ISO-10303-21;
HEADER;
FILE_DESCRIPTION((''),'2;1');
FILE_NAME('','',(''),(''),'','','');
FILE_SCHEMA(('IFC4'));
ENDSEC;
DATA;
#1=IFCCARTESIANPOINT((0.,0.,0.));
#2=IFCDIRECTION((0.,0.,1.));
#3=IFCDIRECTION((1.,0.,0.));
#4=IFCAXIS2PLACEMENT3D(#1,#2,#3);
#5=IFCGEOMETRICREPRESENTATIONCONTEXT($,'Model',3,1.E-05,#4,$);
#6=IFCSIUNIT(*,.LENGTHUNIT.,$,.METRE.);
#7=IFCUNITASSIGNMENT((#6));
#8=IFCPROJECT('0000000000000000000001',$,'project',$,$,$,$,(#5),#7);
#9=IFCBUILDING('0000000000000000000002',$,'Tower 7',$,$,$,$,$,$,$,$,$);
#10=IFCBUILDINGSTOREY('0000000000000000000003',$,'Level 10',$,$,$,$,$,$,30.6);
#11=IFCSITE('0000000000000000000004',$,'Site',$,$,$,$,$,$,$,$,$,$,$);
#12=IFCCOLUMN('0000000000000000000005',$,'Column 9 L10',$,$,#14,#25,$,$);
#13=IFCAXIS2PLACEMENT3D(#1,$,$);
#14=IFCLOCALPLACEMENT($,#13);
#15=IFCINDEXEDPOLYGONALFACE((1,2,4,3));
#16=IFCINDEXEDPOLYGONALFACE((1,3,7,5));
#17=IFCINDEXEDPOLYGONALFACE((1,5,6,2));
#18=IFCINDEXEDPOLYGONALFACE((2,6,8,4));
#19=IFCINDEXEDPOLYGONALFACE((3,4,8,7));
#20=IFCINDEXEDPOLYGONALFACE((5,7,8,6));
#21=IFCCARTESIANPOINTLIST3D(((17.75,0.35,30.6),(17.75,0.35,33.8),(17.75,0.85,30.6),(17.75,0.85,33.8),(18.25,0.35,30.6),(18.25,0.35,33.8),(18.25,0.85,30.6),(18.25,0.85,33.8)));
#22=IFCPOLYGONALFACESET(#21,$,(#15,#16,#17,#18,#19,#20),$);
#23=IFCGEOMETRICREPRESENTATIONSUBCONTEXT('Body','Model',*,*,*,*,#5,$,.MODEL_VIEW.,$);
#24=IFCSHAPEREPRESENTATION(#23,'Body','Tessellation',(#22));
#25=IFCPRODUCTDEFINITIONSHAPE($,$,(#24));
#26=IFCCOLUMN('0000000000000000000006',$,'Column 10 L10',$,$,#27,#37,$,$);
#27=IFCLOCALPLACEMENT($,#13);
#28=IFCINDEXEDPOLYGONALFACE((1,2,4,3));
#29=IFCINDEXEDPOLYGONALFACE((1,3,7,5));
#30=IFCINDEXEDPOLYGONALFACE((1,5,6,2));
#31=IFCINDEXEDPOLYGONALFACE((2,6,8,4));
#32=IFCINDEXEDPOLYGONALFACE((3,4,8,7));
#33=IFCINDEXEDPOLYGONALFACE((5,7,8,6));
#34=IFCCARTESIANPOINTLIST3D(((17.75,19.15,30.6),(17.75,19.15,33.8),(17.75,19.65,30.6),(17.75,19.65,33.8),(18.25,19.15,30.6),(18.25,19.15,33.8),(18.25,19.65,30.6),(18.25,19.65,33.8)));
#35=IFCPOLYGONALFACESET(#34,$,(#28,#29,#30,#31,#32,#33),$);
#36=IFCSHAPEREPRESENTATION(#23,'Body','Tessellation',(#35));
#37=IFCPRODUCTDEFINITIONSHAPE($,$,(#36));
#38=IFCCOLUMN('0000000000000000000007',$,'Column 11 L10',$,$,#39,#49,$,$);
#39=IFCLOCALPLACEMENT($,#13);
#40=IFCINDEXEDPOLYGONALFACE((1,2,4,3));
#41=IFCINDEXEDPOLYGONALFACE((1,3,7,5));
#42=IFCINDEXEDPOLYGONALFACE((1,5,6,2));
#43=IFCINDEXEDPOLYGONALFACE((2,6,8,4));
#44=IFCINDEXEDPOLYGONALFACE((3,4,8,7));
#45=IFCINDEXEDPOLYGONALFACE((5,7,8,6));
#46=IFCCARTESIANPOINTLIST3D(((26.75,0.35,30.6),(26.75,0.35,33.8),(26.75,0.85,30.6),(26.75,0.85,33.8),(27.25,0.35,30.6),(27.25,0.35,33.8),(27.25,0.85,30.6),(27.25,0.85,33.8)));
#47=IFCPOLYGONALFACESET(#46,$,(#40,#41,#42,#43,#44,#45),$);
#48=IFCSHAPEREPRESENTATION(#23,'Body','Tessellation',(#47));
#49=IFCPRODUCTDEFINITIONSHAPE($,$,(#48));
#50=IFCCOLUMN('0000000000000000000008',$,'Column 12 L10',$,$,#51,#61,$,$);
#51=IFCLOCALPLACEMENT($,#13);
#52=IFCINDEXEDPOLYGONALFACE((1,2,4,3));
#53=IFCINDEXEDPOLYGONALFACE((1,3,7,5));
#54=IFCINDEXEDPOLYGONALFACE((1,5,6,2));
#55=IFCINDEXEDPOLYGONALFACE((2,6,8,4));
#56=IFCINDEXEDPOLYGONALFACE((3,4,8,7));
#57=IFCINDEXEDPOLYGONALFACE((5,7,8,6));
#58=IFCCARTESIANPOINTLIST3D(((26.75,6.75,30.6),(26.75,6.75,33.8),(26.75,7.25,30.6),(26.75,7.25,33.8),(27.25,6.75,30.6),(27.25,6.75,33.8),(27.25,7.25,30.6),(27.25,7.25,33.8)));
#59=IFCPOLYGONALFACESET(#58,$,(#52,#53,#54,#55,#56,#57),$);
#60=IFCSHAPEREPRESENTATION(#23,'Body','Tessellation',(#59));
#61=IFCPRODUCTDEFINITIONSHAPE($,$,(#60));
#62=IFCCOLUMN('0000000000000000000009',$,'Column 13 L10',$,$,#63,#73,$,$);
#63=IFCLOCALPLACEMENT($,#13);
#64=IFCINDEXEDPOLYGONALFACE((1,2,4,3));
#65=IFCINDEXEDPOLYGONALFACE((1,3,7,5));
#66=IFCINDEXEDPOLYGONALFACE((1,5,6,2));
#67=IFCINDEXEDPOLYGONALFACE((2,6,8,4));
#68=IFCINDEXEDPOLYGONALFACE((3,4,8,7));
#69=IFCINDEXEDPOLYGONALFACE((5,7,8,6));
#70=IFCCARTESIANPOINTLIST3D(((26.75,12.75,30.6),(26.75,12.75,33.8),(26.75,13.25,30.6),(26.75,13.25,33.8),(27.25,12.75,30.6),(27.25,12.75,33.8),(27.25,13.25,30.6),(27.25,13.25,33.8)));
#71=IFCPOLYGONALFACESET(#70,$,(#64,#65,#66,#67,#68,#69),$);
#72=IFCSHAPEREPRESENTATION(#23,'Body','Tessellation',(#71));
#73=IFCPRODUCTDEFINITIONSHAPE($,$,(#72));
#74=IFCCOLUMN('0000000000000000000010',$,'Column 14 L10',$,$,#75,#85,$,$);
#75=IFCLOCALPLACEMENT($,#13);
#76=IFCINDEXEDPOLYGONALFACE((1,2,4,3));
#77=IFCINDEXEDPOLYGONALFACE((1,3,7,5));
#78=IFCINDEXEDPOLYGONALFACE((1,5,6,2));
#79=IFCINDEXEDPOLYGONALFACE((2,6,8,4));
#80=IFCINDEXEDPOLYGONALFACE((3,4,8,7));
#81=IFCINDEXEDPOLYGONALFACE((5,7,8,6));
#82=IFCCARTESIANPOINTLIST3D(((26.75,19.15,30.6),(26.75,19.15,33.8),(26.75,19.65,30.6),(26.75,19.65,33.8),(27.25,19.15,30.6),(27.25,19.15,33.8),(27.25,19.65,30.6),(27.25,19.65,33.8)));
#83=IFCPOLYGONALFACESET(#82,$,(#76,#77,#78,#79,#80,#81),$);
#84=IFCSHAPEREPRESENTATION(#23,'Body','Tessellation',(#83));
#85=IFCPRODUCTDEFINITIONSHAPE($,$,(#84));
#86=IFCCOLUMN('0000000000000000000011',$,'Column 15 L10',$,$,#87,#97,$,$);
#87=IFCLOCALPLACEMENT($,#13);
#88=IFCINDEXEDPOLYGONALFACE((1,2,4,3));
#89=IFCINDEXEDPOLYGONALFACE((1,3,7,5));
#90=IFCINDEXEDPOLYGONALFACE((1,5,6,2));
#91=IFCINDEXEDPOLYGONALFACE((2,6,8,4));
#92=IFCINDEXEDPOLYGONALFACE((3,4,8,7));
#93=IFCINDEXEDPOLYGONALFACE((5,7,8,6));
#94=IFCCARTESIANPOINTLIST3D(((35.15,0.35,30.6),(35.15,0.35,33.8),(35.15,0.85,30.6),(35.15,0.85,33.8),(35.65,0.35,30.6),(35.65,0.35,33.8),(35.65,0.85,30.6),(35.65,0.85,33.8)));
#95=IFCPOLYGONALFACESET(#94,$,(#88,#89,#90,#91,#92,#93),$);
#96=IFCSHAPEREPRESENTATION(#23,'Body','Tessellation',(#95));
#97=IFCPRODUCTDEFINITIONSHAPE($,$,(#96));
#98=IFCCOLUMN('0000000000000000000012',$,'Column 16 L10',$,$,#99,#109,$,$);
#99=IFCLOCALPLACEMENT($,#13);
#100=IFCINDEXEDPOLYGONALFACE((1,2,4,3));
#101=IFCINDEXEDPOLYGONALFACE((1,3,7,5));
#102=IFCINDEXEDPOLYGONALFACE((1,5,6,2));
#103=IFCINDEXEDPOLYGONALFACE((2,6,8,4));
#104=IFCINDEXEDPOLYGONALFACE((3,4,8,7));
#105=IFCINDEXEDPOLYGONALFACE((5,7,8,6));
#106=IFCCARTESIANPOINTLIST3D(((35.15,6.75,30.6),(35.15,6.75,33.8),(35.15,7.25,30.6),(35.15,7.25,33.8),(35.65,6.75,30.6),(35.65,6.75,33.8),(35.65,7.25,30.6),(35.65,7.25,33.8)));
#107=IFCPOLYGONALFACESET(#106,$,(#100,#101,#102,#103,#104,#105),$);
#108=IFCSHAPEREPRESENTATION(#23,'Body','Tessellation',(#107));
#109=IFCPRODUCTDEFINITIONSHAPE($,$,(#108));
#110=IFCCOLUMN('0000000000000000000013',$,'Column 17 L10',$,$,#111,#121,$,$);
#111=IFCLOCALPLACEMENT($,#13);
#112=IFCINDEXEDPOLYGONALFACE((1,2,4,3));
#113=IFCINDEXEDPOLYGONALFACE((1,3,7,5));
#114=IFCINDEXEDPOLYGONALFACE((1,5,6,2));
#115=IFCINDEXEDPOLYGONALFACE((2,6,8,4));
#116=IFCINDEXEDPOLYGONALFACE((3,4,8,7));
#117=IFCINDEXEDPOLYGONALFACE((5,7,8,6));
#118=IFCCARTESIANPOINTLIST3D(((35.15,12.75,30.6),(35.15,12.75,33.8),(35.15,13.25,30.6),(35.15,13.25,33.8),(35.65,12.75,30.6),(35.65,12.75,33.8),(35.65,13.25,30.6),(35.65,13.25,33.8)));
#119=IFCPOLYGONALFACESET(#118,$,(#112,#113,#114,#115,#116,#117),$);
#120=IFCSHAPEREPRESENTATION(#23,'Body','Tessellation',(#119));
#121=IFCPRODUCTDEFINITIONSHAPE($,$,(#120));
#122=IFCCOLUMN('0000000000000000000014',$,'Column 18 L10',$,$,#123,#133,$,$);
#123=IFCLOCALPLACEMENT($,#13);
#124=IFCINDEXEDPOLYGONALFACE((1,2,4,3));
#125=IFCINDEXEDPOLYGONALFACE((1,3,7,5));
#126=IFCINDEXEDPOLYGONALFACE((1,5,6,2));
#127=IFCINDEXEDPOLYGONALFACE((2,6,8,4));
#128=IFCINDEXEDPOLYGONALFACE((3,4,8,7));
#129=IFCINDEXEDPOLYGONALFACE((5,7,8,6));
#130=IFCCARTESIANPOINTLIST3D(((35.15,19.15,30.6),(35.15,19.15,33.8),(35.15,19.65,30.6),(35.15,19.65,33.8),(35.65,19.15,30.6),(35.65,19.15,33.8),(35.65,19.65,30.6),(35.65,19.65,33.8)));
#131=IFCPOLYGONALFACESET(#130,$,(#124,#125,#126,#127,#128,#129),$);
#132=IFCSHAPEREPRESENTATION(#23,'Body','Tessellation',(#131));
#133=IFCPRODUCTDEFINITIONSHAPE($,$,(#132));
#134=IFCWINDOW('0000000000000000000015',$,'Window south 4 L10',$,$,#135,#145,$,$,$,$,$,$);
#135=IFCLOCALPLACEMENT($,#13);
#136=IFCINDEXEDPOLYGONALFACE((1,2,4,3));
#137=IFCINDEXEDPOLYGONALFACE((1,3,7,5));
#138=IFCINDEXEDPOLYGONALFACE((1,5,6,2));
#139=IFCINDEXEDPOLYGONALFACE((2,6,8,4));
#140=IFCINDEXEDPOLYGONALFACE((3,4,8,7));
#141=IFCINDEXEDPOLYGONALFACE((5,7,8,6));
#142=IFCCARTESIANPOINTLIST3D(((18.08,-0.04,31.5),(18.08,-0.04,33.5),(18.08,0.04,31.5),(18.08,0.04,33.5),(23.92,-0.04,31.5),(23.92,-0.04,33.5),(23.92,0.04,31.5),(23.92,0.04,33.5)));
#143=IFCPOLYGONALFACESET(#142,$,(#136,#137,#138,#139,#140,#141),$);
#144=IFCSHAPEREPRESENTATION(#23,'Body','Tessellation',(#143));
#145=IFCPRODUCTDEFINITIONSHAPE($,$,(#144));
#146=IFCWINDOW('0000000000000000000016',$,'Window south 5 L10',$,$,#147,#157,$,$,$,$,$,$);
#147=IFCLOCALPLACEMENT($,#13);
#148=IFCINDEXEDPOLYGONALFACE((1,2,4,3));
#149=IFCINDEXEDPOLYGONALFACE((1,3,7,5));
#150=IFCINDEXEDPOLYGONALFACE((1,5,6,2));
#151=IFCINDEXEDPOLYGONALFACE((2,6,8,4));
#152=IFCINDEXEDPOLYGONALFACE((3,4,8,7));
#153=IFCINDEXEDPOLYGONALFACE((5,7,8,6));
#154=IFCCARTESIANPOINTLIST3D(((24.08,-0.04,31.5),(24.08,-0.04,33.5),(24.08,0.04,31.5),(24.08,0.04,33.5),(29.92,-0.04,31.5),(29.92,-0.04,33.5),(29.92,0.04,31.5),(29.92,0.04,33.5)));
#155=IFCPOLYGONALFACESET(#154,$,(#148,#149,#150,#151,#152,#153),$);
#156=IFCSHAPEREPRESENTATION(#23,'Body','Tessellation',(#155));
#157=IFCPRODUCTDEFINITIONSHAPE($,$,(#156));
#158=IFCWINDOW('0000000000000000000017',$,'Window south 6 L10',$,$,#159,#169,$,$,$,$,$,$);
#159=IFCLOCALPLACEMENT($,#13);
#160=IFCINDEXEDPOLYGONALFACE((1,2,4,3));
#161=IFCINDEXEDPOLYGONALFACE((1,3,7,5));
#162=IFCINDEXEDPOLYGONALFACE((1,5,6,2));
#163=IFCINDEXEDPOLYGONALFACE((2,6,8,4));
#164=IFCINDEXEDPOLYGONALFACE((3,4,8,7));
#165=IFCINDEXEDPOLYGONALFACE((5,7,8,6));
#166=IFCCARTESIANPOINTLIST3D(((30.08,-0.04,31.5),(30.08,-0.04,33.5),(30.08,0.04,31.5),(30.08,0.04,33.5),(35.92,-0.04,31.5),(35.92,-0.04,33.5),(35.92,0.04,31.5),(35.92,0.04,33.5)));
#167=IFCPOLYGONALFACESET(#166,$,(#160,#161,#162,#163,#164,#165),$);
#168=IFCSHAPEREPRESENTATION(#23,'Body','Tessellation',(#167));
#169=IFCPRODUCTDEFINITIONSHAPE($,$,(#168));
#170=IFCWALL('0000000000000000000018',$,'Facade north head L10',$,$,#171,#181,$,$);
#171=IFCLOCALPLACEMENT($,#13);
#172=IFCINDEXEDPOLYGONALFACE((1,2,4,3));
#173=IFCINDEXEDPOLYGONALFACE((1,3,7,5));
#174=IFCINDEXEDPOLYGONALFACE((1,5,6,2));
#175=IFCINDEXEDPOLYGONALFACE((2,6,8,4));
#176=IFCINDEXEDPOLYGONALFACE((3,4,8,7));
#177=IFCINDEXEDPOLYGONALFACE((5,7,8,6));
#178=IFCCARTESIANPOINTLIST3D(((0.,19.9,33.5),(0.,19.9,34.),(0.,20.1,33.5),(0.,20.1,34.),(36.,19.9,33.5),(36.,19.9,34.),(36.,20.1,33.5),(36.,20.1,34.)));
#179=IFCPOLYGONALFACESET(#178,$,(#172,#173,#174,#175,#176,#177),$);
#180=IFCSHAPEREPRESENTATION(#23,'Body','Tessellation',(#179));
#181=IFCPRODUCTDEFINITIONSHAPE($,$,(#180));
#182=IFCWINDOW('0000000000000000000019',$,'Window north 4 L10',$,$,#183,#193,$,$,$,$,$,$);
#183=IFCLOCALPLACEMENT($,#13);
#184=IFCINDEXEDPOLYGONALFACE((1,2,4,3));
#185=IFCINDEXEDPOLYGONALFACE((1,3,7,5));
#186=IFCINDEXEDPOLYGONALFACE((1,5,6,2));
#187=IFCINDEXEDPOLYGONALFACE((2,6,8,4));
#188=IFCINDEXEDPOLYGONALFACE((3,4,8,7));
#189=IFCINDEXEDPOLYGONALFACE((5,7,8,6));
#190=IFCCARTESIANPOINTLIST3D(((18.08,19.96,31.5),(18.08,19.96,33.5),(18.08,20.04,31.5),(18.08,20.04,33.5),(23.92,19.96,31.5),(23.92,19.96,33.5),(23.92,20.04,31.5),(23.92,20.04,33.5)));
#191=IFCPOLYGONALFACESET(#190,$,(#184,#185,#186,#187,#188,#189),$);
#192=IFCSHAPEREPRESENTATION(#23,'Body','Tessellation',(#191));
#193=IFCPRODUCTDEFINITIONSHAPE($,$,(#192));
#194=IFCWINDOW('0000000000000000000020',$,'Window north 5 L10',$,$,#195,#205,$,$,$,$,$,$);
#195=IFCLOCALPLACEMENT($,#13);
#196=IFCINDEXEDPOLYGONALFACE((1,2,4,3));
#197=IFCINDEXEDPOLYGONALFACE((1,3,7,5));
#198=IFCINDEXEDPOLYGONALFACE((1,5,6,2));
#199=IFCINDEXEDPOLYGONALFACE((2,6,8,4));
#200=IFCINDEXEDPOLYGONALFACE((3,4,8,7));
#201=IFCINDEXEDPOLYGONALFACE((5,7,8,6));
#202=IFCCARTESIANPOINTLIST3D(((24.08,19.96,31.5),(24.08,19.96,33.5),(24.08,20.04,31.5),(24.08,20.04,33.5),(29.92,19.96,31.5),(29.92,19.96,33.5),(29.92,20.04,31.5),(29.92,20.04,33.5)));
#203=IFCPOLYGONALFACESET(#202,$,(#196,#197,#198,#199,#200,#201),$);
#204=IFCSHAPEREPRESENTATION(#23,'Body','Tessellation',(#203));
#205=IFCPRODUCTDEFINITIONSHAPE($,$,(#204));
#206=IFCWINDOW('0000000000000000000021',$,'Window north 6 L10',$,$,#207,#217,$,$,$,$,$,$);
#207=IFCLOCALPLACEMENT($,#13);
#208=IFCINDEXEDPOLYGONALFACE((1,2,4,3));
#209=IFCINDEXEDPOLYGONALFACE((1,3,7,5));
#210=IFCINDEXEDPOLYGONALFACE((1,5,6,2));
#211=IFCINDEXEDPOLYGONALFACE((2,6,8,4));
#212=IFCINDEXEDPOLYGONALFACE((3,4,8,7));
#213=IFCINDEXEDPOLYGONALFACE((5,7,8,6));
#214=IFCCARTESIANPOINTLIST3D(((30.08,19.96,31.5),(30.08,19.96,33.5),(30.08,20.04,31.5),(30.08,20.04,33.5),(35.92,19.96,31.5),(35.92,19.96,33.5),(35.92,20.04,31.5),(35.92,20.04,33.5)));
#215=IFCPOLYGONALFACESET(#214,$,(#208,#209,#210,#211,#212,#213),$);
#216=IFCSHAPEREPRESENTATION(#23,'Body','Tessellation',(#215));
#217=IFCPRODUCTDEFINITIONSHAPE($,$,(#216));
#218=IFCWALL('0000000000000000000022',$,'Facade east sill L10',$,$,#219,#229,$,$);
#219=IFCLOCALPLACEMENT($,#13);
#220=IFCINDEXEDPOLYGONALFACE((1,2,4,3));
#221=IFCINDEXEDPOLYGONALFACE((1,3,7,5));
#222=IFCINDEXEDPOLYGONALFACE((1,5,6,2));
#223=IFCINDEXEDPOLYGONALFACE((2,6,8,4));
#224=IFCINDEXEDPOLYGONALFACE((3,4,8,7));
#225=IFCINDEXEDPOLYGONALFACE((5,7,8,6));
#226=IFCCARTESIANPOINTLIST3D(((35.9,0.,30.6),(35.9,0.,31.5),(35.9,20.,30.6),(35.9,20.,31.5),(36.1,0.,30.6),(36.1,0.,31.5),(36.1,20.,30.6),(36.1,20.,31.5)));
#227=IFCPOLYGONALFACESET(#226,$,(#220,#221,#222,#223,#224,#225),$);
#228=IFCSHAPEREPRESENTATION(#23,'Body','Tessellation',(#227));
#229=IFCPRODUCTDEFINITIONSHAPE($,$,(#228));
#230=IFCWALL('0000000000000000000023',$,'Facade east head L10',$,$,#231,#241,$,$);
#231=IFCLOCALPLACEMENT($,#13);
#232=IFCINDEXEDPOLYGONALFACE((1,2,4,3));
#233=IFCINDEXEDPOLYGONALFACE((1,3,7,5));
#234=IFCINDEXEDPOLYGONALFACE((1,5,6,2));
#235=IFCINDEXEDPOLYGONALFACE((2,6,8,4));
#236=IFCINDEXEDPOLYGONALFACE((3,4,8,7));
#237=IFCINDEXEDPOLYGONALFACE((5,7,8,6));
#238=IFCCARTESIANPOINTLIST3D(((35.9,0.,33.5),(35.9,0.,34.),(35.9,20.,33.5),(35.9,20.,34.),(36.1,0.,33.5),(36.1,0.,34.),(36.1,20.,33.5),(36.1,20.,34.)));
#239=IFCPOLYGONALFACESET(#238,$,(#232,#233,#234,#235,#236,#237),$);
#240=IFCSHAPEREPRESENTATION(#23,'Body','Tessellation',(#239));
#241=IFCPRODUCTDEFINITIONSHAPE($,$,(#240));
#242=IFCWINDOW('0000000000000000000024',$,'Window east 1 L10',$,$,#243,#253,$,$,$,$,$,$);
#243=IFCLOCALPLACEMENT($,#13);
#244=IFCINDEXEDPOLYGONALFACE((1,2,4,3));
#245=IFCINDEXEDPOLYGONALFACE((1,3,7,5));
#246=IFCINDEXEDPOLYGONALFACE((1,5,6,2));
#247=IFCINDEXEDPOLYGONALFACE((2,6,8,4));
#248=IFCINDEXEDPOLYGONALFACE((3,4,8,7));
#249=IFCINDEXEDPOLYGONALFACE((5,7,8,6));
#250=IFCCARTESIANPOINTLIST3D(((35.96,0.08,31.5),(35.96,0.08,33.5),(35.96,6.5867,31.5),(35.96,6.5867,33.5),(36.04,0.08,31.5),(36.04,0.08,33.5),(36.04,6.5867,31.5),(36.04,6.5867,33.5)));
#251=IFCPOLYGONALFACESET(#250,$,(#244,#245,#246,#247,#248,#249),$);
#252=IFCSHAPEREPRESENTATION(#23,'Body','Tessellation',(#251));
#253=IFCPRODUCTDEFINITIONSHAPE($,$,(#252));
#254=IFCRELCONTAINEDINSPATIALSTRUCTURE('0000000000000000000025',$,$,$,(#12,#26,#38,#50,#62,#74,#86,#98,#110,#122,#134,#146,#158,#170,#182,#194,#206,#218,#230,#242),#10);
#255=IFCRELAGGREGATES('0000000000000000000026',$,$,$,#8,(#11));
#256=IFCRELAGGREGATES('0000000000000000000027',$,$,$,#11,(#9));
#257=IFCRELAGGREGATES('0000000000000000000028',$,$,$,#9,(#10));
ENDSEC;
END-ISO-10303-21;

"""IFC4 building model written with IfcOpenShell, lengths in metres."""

from ifc_helpers import new_model, si_unit, frame, origin, origin_with_axes, origin_2d, place, context, subcontext, project, spatial, rectangle, extrude, element, save


model = new_model("IFC4")

# Units and contexts
model_context = context("Model", 3, precision=1e-05, world=origin_with_axes())
body_context = subcontext(model_context, "Body", "Model", "MODEL_VIEW")
ifc_project = project(units=[si_unit("LENGTHUNIT", "METRE")], contexts=[model_context])

# Site, building, storey
site = spatial("IfcSite", under=ifc_project, Name="Site")
building = spatial("IfcBuilding", under=site, Name="Tower 7")
storey = spatial("IfcBuildingStorey", under=building, Name="Level 10", Elevation=30.6)

# Columns
for number, where, z_axis, x_axis, name in (
    (1, (18.0, 0.6, 30.6), (0.0, 0.0, 1.0), (1.0, 0.0, 0.0), "Column 9 L10"),
    (2, (18.0, 19.4, 30.6), (0.0, 0.0, 1.0), (1.0, 0.0, 0.0), "Column 10 L10"),
    (3, (27.0, 0.6, 30.6), (0.0, 0.0, 1.0), (1.0, 0.0, 0.0), "Column 11 L10"),
    (4, (27.0, 7.0, 30.6), (0.0, 0.0, 1.0), (1.0, 0.0, 0.0), "Column 12 L10"),
    (5, (27.0, 13.0, 30.6), (0.0, 0.0, 1.0), (1.0, 0.0, 0.0), "Column 13 L10"),
    (6, (27.0, 19.4, 30.6), (0.0, 0.0, 1.0), (1.0, 0.0, 0.0), "Column 14 L10"),
    (7, (35.4, 0.6, 30.6), (0.0, 0.0, 1.0), (1.0, 0.0, 0.0), "Column 15 L10"),
    (8, (35.4, 7.0, 30.6), (0.0, 0.0, 1.0), (1.0, 0.0, 0.0), "Column 16 L10"),
    (9, (35.4, 13.0, 30.6), (0.0, 0.0, 1.0), (1.0, 0.0, 0.0), "Column 17 L10"),
    (10, (35.4, 19.4, 30.6), (0.0, 0.0, 1.0), (1.0, 0.0, 0.0), "Column 18 L10"),
):
    element("IfcColumn", number, at=place(None, frame(where, z_axis=z_axis, x_axis=x_axis)), inside=storey, Name=name, context=body_context, shape_type="SweptSolid", body=[
        extrude(rectangle(XDim=0.5, YDim=0.5, at=origin_2d()), origin(), (0.0, 0.0, 1.0), 3.2),
    ])

# Windows
for number, where, z_axis, x_axis, name in (
    (11, (21.0, 0.0, 31.5), (0.0, 0.0, 1.0), (1.0, 0.0, 0.0), "Window south 4 L10"),
    (12, (27.0, 0.0, 31.5), (0.0, 0.0, 1.0), (1.0, 0.0, 0.0), "Window south 5 L10"),
    (13, (33.0, 0.0, 31.5), (0.0, 0.0, 1.0), (1.0, 0.0, 0.0), "Window south 6 L10"),
):
    element("IfcWindow", number, at=place(None, frame(where, z_axis=z_axis, x_axis=x_axis)), inside=storey, Name=name, context=body_context, shape_type="SweptSolid", body=[
        extrude(rectangle(XDim=5.84, YDim=0.08, at=origin_2d()), origin(), (0.0, 0.0, 1.0), 2.0),
    ])

# Wall
wall_1_placement = place(None, frame((18.0, 20.0, 33.5), z_axis=(0.0, 0.0, 1.0), x_axis=(1.0, 0.0, 0.0)))
element("IfcWall", 14, at=wall_1_placement, inside=storey, Name="Facade north head L10", context=body_context, shape_type="SweptSolid", body=[
    extrude(rectangle(XDim=36.0, YDim=0.2, at=origin_2d()), origin(), (0.0, 0.0, 1.0), 0.5),
])

# Windows
for number, where, z_axis, x_axis, name in (
    (15, (21.0, 20.0, 31.5), (0.0, 0.0, 1.0), (1.0, 0.0, 0.0), "Window north 4 L10"),
    (16, (27.0, 20.0, 31.5), (0.0, 0.0, 1.0), (1.0, 0.0, 0.0), "Window north 5 L10"),
    (17, (33.0, 20.0, 31.5), (0.0, 0.0, 1.0), (1.0, 0.0, 0.0), "Window north 6 L10"),
):
    element("IfcWindow", number, at=place(None, frame(where, z_axis=z_axis, x_axis=x_axis)), inside=storey, Name=name, context=body_context, shape_type="SweptSolid", body=[
        extrude(rectangle(XDim=5.84, YDim=0.08, at=origin_2d()), origin(), (0.0, 0.0, 1.0), 2.0),
    ])

# Walls
wall_2_placement = place(None, frame((36.0, 10.0, 30.6), z_axis=(0.0, 0.0, 1.0), x_axis=(1.0, 0.0, 0.0)))
element("IfcWall", 18, at=wall_2_placement, inside=storey, Name="Facade east sill L10", context=body_context, shape_type="SweptSolid", body=[
    extrude(rectangle(XDim=0.2, YDim=20.0, at=origin_2d()), origin(), (0.0, 0.0, 1.0), 0.9),
])
wall_3_placement = place(None, frame((36.0, 10.0, 33.5), z_axis=(0.0, 0.0, 1.0), x_axis=(1.0, 0.0, 0.0)))
element("IfcWall", 19, at=wall_3_placement, inside=storey, Name="Facade east head L10", context=body_context, shape_type="SweptSolid", body=[
    extrude(rectangle(XDim=0.2, YDim=20.0, at=origin_2d()), origin(), (0.0, 0.0, 1.0), 0.5),
])

# Window
for number, where, z_axis, x_axis, name in (
    (20, (36.0, 3.3333, 31.5), (0.0, 0.0, 1.0), (1.0, 0.0, 0.0), "Window east 1 L10"),
):
    element("IfcWindow", number, at=place(None, frame(where, z_axis=z_axis, x_axis=x_axis)), inside=storey, Name=name, context=body_context, shape_type="SweptSolid", body=[
        extrude(rectangle(XDim=0.08, YDim=6.5067, at=origin_2d()), origin(), (0.0, 0.0, 1.0), 2.0),
    ])

save(model, "model.ifc")
